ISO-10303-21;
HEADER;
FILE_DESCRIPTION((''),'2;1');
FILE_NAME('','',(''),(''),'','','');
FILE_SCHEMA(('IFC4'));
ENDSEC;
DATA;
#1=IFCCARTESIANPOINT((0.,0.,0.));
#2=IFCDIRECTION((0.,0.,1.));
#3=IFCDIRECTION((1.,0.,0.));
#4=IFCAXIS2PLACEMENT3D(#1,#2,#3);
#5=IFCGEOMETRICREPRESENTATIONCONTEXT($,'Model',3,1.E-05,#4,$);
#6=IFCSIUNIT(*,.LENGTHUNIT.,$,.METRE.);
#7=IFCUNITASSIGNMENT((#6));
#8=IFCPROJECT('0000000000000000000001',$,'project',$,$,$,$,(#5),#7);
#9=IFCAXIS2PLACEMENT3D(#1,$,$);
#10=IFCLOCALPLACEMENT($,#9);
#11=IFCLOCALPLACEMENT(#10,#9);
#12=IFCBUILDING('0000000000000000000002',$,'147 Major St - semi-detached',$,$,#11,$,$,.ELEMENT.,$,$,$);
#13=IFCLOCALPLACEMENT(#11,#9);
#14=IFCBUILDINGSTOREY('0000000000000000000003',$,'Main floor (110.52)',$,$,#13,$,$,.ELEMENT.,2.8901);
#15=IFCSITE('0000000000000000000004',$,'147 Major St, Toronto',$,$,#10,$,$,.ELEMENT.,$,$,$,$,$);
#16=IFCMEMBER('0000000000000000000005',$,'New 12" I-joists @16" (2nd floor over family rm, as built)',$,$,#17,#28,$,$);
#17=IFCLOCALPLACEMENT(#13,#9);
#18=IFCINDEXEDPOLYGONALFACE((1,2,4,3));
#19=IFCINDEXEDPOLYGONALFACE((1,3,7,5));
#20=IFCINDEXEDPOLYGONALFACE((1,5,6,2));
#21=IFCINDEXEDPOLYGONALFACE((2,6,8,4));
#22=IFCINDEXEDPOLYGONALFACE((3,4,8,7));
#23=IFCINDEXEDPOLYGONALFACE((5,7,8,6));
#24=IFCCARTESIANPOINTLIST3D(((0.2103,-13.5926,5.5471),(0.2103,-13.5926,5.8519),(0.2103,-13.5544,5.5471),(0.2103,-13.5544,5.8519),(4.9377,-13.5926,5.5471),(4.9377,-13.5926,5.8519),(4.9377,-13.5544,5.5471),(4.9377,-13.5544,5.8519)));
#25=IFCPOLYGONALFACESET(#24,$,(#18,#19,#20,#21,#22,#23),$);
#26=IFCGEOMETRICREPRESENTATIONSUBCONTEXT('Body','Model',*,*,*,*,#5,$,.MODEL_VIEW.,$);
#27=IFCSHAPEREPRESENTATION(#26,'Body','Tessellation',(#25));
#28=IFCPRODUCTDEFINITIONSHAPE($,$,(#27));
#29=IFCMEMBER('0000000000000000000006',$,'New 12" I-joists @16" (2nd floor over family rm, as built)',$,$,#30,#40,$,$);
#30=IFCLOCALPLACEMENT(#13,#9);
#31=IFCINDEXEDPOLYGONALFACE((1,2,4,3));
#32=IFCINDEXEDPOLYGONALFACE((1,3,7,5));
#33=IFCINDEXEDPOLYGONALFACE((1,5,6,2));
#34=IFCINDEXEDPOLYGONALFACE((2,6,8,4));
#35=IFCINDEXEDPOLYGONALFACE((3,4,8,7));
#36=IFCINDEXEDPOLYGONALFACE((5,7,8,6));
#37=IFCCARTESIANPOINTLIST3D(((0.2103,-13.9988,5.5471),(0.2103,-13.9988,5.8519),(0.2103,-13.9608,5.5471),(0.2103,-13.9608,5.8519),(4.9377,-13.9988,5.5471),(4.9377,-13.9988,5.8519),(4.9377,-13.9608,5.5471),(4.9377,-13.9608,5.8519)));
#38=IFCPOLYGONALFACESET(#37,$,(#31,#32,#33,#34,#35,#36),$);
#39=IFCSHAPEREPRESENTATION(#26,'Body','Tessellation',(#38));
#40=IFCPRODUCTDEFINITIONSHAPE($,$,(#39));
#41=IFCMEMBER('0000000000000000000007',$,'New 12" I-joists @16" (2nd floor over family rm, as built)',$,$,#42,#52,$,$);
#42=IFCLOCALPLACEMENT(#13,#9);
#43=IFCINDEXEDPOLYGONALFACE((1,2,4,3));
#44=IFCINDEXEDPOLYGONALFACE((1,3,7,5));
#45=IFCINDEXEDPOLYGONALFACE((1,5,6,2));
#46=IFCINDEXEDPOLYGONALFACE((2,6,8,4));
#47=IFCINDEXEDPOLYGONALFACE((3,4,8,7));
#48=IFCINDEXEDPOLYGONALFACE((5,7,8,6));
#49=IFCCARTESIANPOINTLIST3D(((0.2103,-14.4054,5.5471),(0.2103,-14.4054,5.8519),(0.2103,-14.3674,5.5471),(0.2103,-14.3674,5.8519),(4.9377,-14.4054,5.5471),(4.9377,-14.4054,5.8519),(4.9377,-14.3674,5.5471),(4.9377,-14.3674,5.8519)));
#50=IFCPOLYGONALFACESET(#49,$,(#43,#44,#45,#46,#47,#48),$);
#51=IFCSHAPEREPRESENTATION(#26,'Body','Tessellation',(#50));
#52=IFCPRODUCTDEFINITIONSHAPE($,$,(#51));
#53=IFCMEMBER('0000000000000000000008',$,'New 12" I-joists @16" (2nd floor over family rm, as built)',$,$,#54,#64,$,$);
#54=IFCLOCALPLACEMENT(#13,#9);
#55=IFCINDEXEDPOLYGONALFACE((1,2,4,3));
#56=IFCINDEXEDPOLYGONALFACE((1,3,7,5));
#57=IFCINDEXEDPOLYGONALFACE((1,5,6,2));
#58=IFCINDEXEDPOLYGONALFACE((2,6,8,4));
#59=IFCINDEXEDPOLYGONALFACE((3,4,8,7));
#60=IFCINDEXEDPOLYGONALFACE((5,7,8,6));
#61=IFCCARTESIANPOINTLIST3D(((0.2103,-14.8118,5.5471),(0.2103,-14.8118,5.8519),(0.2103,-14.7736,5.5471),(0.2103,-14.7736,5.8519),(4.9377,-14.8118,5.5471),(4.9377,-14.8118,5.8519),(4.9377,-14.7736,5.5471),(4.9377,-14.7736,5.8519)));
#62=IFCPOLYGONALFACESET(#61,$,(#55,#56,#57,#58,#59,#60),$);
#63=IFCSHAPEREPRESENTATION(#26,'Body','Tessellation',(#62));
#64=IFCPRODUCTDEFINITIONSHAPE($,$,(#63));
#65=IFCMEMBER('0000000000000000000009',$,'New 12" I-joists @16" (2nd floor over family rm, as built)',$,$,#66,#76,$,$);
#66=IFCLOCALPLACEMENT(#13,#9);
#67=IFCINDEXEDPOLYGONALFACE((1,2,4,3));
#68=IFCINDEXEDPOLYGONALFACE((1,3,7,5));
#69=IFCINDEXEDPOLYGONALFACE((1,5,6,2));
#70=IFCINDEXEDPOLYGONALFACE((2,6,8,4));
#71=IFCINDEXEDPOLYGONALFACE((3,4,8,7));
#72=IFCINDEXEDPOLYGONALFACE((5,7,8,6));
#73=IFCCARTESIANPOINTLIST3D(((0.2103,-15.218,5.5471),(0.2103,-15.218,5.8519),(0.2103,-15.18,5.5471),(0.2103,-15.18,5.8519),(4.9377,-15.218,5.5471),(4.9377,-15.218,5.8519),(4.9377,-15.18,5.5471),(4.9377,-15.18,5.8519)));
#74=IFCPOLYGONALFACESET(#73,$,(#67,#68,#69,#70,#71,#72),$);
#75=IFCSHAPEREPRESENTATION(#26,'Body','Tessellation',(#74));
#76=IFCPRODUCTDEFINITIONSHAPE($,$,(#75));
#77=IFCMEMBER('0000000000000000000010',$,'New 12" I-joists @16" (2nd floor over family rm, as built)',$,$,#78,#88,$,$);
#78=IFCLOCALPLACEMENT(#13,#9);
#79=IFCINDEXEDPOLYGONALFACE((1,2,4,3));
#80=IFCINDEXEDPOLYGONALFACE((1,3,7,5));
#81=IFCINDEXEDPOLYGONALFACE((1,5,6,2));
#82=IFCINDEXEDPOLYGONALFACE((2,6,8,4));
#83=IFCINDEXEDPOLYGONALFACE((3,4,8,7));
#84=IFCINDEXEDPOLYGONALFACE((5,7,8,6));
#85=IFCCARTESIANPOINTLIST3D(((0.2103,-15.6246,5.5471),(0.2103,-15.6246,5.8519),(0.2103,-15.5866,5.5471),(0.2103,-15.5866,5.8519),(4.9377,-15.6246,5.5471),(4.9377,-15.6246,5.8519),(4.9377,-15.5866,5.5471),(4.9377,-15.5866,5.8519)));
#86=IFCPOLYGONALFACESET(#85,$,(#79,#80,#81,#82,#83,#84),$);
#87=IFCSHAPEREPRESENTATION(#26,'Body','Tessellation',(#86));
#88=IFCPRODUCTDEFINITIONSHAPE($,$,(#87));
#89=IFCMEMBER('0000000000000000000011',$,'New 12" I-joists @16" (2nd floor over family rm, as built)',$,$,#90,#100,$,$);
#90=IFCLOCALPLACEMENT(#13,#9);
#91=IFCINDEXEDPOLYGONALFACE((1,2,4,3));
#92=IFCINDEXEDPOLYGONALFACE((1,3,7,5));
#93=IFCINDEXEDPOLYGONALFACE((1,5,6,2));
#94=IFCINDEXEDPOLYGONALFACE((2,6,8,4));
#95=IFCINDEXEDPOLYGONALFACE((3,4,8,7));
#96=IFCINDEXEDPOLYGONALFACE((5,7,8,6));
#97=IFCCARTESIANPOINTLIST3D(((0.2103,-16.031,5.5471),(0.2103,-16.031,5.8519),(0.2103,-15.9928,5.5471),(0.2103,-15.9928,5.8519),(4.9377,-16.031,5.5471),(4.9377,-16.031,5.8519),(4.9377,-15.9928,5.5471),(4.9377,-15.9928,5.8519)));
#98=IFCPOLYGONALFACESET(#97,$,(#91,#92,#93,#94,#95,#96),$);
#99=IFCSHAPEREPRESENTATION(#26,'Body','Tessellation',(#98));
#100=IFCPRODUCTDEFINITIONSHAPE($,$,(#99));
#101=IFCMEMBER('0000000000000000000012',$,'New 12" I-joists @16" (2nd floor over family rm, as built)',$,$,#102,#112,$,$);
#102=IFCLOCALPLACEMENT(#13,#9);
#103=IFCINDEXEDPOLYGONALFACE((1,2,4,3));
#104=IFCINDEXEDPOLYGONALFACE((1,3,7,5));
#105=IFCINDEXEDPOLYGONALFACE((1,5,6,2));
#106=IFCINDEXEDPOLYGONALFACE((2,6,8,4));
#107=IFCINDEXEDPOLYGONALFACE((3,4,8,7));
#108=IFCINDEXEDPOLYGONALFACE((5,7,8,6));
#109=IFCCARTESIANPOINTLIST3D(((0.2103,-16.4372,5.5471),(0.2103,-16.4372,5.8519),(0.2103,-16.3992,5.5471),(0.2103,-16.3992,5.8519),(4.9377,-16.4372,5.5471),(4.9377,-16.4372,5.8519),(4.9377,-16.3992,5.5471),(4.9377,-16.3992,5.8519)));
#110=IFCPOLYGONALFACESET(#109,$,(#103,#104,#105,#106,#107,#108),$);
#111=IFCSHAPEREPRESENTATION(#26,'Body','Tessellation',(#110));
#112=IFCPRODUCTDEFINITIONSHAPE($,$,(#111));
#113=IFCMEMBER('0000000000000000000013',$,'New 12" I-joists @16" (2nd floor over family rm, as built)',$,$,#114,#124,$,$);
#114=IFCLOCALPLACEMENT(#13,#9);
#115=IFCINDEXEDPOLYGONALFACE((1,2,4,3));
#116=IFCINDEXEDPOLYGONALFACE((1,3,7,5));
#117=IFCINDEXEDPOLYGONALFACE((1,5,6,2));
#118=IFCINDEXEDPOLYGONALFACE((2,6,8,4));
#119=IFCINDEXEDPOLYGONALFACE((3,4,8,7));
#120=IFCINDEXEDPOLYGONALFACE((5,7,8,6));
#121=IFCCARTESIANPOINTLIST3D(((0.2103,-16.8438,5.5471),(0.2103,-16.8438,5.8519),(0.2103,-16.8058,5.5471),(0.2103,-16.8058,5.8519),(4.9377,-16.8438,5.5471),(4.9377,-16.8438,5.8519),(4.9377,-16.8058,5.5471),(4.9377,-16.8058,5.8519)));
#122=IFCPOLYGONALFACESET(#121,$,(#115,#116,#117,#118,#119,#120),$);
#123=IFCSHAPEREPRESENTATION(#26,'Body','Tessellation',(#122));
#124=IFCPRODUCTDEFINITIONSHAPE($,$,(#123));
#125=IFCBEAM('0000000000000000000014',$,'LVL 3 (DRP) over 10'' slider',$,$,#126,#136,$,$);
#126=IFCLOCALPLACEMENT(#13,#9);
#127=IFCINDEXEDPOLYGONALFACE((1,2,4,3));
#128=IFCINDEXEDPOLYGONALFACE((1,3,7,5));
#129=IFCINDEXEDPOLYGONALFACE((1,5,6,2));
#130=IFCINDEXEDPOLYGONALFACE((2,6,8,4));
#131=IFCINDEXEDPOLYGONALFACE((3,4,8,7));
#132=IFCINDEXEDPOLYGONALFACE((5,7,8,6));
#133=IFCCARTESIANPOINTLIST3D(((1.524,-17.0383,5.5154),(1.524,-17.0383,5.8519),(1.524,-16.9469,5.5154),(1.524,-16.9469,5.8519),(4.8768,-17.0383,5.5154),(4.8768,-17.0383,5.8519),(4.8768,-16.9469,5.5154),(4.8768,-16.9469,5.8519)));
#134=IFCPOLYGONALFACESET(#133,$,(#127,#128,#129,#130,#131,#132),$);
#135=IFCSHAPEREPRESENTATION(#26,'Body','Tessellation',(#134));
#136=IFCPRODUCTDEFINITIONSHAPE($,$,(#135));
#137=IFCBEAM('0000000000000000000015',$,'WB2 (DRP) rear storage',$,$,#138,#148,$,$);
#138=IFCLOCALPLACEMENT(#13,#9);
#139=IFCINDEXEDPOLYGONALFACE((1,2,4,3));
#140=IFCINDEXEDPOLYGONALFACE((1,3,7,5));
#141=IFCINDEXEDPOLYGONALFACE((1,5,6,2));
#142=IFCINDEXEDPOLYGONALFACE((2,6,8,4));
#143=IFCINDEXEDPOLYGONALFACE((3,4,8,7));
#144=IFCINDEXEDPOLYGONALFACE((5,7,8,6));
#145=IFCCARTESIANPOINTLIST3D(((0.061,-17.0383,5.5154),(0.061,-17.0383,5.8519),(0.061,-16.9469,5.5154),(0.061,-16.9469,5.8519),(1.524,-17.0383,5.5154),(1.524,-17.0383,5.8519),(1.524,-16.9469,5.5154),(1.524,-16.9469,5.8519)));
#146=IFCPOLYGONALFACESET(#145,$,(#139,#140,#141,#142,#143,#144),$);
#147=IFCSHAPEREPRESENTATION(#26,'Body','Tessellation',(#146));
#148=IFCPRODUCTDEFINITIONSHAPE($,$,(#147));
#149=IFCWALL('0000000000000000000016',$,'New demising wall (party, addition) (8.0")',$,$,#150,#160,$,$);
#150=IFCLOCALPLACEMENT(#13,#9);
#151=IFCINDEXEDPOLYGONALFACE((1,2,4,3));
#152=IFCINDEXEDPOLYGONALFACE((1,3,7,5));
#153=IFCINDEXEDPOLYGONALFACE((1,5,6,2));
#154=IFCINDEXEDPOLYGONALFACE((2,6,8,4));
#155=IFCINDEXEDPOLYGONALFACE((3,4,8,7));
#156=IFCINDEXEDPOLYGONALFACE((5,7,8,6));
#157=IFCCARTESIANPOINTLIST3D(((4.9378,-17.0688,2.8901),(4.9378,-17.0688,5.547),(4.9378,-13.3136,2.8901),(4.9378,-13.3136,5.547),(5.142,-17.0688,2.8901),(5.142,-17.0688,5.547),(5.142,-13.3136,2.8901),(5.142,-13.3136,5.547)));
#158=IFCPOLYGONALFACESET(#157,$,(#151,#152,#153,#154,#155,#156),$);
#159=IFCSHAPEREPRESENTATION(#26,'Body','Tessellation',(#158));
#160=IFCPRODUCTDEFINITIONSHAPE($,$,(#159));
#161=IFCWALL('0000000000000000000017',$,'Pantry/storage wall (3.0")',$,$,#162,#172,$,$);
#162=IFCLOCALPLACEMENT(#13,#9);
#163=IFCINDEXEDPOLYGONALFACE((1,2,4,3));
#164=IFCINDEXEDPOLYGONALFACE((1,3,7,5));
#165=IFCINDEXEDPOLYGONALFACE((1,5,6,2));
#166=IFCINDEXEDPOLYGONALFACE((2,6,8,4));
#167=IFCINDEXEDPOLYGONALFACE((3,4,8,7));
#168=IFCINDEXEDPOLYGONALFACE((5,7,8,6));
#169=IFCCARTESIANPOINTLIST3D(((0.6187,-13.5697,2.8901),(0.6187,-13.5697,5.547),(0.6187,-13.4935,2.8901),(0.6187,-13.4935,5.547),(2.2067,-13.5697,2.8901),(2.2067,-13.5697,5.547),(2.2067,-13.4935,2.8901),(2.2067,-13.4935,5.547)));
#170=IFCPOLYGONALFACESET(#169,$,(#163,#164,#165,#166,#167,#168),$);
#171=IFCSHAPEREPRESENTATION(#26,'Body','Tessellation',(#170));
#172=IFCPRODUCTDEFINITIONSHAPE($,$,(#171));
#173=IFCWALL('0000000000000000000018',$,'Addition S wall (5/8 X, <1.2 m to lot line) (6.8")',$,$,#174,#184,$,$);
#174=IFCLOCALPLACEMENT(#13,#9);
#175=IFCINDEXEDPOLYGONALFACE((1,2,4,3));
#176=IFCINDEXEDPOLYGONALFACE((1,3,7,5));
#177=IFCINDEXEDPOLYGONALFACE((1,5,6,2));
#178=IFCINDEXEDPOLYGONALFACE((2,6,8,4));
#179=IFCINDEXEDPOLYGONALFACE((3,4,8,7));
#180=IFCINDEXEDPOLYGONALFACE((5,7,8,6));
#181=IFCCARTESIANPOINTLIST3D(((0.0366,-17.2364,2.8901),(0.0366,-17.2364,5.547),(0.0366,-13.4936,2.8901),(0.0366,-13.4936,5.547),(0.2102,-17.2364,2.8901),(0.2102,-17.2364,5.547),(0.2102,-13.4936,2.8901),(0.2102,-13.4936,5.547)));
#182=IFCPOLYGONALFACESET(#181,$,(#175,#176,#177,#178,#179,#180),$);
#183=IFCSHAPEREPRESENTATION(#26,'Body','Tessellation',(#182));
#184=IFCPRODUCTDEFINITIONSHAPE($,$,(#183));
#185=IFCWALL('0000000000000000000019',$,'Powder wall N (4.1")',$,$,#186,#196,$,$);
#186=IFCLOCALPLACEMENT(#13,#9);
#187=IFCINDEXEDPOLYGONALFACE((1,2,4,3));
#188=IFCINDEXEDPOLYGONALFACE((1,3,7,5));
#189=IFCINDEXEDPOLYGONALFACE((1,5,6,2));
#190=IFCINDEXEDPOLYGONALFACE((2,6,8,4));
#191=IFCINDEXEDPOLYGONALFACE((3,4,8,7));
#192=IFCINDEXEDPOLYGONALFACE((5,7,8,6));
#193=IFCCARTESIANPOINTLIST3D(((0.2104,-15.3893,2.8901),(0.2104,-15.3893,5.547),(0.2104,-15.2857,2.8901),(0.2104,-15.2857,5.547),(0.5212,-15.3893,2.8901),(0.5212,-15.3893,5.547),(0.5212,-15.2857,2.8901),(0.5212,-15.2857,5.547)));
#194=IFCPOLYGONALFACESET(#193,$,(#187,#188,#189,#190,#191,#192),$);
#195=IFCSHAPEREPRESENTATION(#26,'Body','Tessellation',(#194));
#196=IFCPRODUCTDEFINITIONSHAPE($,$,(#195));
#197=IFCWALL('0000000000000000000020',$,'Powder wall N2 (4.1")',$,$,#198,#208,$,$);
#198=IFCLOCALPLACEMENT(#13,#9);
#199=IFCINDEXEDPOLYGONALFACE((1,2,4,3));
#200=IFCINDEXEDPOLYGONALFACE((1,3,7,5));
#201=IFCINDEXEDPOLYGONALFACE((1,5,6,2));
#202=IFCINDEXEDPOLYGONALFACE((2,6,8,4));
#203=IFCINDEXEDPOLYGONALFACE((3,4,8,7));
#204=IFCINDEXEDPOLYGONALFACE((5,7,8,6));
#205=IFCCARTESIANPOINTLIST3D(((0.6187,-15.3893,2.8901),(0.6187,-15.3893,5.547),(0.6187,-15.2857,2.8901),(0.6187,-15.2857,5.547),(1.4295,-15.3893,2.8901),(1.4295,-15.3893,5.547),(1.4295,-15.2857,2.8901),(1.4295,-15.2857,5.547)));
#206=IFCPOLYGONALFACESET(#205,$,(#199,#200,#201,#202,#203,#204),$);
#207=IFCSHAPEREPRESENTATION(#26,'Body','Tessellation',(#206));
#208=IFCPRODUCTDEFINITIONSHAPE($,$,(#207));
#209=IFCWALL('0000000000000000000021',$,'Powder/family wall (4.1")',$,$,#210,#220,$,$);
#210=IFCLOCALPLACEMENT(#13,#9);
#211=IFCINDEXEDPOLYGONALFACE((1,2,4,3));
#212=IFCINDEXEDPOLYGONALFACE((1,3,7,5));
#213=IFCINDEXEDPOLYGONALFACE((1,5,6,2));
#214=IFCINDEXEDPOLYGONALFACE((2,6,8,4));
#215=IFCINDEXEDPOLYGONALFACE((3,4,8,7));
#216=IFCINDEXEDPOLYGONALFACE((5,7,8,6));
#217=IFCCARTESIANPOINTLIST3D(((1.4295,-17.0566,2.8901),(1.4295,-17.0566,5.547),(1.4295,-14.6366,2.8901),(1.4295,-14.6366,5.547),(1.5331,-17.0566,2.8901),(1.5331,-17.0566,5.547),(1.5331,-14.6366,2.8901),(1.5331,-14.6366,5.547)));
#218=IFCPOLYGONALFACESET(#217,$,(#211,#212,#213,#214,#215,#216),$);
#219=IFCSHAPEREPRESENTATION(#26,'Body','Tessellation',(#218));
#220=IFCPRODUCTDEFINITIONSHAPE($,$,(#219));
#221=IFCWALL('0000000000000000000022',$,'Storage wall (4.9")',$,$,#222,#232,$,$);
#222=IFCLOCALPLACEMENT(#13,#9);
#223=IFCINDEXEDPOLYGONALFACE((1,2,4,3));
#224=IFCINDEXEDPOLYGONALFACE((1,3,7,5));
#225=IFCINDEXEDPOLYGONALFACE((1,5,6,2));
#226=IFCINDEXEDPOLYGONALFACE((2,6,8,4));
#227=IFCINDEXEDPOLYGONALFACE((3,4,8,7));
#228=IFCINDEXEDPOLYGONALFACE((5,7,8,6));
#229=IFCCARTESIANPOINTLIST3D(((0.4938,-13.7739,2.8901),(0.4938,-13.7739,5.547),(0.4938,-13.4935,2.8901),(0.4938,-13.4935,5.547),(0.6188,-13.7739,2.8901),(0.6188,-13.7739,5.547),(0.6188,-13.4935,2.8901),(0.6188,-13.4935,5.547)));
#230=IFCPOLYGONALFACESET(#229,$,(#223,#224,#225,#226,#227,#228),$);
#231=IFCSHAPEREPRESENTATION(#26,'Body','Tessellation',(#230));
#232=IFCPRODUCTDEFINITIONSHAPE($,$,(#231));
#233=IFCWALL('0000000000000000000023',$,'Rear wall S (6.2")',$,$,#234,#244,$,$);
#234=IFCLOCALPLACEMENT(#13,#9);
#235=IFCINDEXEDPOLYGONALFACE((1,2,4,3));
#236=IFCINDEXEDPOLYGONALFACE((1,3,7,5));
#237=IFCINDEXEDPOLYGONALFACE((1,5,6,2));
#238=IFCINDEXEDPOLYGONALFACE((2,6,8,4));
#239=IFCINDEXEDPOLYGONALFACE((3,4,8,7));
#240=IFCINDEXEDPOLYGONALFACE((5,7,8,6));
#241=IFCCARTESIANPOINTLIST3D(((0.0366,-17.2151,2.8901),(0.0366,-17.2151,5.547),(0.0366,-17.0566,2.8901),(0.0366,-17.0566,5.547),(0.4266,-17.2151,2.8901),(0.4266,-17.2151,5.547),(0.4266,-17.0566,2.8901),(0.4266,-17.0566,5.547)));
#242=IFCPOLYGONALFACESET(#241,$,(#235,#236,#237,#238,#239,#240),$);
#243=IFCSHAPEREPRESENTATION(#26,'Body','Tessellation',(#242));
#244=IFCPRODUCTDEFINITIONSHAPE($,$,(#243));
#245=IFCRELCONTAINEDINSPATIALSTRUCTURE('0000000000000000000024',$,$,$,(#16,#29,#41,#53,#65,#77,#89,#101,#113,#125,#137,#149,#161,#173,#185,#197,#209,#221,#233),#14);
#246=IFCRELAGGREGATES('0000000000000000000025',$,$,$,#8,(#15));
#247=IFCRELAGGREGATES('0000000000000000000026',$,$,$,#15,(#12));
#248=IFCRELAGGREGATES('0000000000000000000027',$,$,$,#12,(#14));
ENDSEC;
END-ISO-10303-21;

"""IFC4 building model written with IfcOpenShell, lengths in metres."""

from ifc_helpers import new_model, si_unit, frame, origin, origin_with_axes, place, context, subcontext, project, spatial, rectangle, extrude, element, save


model = new_model("IFC4")

# Units and contexts
model_context = context("Model", 3, precision=1e-05, world=origin_with_axes())
body_context = subcontext(model_context, "Body", "Model", "MODEL_VIEW")
ifc_project = project(units=[si_unit("LENGTHUNIT", "METRE")], contexts=[model_context])

# Site, building, storey
site_placement = place(None, origin())
site = spatial("IfcSite", under=ifc_project, at=site_placement, Name="147 Major St, Toronto", CompositionType="ELEMENT")
building_placement = place(site_placement, origin())
building = spatial("IfcBuilding", under=site, at=building_placement, Name="147 Major St - semi-detached", CompositionType="ELEMENT")
storey_placement = place(building_placement, origin())
storey = spatial("IfcBuildingStorey", under=building, at=storey_placement, Name="Main floor (110.52)", CompositionType="ELEMENT", Elevation=2.8901)

# Members
for number, where, name in (
    (1, (2.574, -13.5735, 5.5471), "New 12\" I-joists @16\" (2nd floor over family rm, as built)"),
    (2, (2.574, -13.9798, 5.5471), "New 12\" I-joists @16\" (2nd floor over family rm, as built)"),
    (3, (2.574, -14.3864, 5.5471), "New 12\" I-joists @16\" (2nd floor over family rm, as built)"),
    (4, (2.574, -14.7927, 5.5471), "New 12\" I-joists @16\" (2nd floor over family rm, as built)"),
    (5, (2.574, -15.199, 5.5471), "New 12\" I-joists @16\" (2nd floor over family rm, as built)"),
    (6, (2.574, -15.6056, 5.5471), "New 12\" I-joists @16\" (2nd floor over family rm, as built)"),
    (7, (2.574, -16.0119, 5.5471), "New 12\" I-joists @16\" (2nd floor over family rm, as built)"),
    (8, (2.574, -16.4182, 5.5471), "New 12\" I-joists @16\" (2nd floor over family rm, as built)"),
    (9, (2.574, -16.8248, 5.5471), "New 12\" I-joists @16\" (2nd floor over family rm, as built)"),
):
    element("IfcMember", number, at=place(storey_placement, frame(where)), inside=storey, Name=name, context=body_context, shape_type="SweptSolid", body=[
        extrude(rectangle(XDim=4.7274, YDim=0.0381), origin_with_axes(), (0.0, 0.0, 1.0), 0.3048),
    ])

# Beams
beam_1_placement = place(storey_placement, frame((3.2004, -16.9926, 5.5154)))
element("IfcBeam", 10, at=beam_1_placement, inside=storey, Name="LVL 3 (DRP) over 10' slider", context=body_context, shape_type="SweptSolid", body=[
    extrude(rectangle(XDim=3.3528, YDim=0.0914), origin_with_axes(), (0.0, 0.0, 1.0), 0.3365),
])
beam_2_placement = place(storey_placement, frame((0.7925, -16.9926, 5.5154)))
element("IfcBeam", 11, at=beam_2_placement, inside=storey, Name="WB2 (DRP) rear storage", context=body_context, shape_type="SweptSolid", body=[
    extrude(rectangle(XDim=1.463, YDim=0.0914), origin_with_axes(), (0.0, 0.0, 1.0), 0.3365),
])

# Walls
wall_1_placement = place(storey_placement, frame((5.0399, -15.1912, 2.8901)))
element("IfcWall", 12, at=wall_1_placement, inside=storey, Name="New demising wall (party, addition) (8.0\")", context=body_context, shape_type="SweptSolid", body=[
    extrude(rectangle(XDim=0.2042, YDim=3.7551), origin_with_axes(), (0.0, 0.0, 1.0), 2.6569),
])
wall_2_placement = place(storey_placement, frame((1.4127, -13.5316, 2.8901)))
element("IfcWall", 13, at=wall_2_placement, inside=storey, Name="Pantry/storage wall (3.0\")", context=body_context, shape_type="SweptSolid", body=[
    extrude(rectangle(XDim=1.588, YDim=0.0762), origin_with_axes(), (0.0, 0.0, 1.0), 2.6569),
])
wall_3_placement = place(storey_placement, frame((0.1234, -15.365, 2.8901)))
element("IfcWall", 14, at=wall_3_placement, inside=storey, Name="Addition S wall (5/8 X, <1.2 m to lot line) (6.8\")", context=body_context, shape_type="SweptSolid", body=[
    extrude(rectangle(XDim=0.1737, YDim=3.7429), origin_with_axes(), (0.0, 0.0, 1.0), 2.6569),
])
wall_4_placement = place(storey_placement, frame((0.3658, -15.3375, 2.8901)))
element("IfcWall", 15, at=wall_4_placement, inside=storey, Name="Powder wall N (4.1\")", context=body_context, shape_type="SweptSolid", body=[
    extrude(rectangle(XDim=0.3109, YDim=0.1036), origin_with_axes(), (0.0, 0.0, 1.0), 2.6569),
])
wall_5_placement = place(storey_placement, frame((1.0241, -15.3375, 2.8901)))
element("IfcWall", 16, at=wall_5_placement, inside=storey, Name="Powder wall N2 (4.1\")", context=body_context, shape_type="SweptSolid", body=[
    extrude(rectangle(XDim=0.8108, YDim=0.1036), origin_with_axes(), (0.0, 0.0, 1.0), 2.6569),
])
wall_6_placement = place(storey_placement, frame((1.4813, -15.8466, 2.8901)))
element("IfcWall", 17, at=wall_6_placement, inside=storey, Name="Powder/family wall (4.1\")", context=body_context, shape_type="SweptSolid", body=[
    extrude(rectangle(XDim=0.1036, YDim=2.4201), origin_with_axes(), (0.0, 0.0, 1.0), 2.6569),
])
wall_7_placement = place(storey_placement, frame((0.5563, -13.6337, 2.8901)))
element("IfcWall", 18, at=wall_7_placement, inside=storey, Name="Storage wall (4.9\")", context=body_context, shape_type="SweptSolid", body=[
    extrude(rectangle(XDim=0.125, YDim=0.2804), origin_with_axes(), (0.0, 0.0, 1.0), 2.6569),
])
wall_8_placement = place(storey_placement, frame((0.2316, -17.1359, 2.8901)))
element("IfcWall", 19, at=wall_8_placement, inside=storey, Name="Rear wall S (6.2\")", context=body_context, shape_type="SweptSolid", body=[
    extrude(rectangle(XDim=0.3901, YDim=0.1585), origin_with_axes(), (0.0, 0.0, 1.0), 2.6569),
])

save(model, "model.ifc")
